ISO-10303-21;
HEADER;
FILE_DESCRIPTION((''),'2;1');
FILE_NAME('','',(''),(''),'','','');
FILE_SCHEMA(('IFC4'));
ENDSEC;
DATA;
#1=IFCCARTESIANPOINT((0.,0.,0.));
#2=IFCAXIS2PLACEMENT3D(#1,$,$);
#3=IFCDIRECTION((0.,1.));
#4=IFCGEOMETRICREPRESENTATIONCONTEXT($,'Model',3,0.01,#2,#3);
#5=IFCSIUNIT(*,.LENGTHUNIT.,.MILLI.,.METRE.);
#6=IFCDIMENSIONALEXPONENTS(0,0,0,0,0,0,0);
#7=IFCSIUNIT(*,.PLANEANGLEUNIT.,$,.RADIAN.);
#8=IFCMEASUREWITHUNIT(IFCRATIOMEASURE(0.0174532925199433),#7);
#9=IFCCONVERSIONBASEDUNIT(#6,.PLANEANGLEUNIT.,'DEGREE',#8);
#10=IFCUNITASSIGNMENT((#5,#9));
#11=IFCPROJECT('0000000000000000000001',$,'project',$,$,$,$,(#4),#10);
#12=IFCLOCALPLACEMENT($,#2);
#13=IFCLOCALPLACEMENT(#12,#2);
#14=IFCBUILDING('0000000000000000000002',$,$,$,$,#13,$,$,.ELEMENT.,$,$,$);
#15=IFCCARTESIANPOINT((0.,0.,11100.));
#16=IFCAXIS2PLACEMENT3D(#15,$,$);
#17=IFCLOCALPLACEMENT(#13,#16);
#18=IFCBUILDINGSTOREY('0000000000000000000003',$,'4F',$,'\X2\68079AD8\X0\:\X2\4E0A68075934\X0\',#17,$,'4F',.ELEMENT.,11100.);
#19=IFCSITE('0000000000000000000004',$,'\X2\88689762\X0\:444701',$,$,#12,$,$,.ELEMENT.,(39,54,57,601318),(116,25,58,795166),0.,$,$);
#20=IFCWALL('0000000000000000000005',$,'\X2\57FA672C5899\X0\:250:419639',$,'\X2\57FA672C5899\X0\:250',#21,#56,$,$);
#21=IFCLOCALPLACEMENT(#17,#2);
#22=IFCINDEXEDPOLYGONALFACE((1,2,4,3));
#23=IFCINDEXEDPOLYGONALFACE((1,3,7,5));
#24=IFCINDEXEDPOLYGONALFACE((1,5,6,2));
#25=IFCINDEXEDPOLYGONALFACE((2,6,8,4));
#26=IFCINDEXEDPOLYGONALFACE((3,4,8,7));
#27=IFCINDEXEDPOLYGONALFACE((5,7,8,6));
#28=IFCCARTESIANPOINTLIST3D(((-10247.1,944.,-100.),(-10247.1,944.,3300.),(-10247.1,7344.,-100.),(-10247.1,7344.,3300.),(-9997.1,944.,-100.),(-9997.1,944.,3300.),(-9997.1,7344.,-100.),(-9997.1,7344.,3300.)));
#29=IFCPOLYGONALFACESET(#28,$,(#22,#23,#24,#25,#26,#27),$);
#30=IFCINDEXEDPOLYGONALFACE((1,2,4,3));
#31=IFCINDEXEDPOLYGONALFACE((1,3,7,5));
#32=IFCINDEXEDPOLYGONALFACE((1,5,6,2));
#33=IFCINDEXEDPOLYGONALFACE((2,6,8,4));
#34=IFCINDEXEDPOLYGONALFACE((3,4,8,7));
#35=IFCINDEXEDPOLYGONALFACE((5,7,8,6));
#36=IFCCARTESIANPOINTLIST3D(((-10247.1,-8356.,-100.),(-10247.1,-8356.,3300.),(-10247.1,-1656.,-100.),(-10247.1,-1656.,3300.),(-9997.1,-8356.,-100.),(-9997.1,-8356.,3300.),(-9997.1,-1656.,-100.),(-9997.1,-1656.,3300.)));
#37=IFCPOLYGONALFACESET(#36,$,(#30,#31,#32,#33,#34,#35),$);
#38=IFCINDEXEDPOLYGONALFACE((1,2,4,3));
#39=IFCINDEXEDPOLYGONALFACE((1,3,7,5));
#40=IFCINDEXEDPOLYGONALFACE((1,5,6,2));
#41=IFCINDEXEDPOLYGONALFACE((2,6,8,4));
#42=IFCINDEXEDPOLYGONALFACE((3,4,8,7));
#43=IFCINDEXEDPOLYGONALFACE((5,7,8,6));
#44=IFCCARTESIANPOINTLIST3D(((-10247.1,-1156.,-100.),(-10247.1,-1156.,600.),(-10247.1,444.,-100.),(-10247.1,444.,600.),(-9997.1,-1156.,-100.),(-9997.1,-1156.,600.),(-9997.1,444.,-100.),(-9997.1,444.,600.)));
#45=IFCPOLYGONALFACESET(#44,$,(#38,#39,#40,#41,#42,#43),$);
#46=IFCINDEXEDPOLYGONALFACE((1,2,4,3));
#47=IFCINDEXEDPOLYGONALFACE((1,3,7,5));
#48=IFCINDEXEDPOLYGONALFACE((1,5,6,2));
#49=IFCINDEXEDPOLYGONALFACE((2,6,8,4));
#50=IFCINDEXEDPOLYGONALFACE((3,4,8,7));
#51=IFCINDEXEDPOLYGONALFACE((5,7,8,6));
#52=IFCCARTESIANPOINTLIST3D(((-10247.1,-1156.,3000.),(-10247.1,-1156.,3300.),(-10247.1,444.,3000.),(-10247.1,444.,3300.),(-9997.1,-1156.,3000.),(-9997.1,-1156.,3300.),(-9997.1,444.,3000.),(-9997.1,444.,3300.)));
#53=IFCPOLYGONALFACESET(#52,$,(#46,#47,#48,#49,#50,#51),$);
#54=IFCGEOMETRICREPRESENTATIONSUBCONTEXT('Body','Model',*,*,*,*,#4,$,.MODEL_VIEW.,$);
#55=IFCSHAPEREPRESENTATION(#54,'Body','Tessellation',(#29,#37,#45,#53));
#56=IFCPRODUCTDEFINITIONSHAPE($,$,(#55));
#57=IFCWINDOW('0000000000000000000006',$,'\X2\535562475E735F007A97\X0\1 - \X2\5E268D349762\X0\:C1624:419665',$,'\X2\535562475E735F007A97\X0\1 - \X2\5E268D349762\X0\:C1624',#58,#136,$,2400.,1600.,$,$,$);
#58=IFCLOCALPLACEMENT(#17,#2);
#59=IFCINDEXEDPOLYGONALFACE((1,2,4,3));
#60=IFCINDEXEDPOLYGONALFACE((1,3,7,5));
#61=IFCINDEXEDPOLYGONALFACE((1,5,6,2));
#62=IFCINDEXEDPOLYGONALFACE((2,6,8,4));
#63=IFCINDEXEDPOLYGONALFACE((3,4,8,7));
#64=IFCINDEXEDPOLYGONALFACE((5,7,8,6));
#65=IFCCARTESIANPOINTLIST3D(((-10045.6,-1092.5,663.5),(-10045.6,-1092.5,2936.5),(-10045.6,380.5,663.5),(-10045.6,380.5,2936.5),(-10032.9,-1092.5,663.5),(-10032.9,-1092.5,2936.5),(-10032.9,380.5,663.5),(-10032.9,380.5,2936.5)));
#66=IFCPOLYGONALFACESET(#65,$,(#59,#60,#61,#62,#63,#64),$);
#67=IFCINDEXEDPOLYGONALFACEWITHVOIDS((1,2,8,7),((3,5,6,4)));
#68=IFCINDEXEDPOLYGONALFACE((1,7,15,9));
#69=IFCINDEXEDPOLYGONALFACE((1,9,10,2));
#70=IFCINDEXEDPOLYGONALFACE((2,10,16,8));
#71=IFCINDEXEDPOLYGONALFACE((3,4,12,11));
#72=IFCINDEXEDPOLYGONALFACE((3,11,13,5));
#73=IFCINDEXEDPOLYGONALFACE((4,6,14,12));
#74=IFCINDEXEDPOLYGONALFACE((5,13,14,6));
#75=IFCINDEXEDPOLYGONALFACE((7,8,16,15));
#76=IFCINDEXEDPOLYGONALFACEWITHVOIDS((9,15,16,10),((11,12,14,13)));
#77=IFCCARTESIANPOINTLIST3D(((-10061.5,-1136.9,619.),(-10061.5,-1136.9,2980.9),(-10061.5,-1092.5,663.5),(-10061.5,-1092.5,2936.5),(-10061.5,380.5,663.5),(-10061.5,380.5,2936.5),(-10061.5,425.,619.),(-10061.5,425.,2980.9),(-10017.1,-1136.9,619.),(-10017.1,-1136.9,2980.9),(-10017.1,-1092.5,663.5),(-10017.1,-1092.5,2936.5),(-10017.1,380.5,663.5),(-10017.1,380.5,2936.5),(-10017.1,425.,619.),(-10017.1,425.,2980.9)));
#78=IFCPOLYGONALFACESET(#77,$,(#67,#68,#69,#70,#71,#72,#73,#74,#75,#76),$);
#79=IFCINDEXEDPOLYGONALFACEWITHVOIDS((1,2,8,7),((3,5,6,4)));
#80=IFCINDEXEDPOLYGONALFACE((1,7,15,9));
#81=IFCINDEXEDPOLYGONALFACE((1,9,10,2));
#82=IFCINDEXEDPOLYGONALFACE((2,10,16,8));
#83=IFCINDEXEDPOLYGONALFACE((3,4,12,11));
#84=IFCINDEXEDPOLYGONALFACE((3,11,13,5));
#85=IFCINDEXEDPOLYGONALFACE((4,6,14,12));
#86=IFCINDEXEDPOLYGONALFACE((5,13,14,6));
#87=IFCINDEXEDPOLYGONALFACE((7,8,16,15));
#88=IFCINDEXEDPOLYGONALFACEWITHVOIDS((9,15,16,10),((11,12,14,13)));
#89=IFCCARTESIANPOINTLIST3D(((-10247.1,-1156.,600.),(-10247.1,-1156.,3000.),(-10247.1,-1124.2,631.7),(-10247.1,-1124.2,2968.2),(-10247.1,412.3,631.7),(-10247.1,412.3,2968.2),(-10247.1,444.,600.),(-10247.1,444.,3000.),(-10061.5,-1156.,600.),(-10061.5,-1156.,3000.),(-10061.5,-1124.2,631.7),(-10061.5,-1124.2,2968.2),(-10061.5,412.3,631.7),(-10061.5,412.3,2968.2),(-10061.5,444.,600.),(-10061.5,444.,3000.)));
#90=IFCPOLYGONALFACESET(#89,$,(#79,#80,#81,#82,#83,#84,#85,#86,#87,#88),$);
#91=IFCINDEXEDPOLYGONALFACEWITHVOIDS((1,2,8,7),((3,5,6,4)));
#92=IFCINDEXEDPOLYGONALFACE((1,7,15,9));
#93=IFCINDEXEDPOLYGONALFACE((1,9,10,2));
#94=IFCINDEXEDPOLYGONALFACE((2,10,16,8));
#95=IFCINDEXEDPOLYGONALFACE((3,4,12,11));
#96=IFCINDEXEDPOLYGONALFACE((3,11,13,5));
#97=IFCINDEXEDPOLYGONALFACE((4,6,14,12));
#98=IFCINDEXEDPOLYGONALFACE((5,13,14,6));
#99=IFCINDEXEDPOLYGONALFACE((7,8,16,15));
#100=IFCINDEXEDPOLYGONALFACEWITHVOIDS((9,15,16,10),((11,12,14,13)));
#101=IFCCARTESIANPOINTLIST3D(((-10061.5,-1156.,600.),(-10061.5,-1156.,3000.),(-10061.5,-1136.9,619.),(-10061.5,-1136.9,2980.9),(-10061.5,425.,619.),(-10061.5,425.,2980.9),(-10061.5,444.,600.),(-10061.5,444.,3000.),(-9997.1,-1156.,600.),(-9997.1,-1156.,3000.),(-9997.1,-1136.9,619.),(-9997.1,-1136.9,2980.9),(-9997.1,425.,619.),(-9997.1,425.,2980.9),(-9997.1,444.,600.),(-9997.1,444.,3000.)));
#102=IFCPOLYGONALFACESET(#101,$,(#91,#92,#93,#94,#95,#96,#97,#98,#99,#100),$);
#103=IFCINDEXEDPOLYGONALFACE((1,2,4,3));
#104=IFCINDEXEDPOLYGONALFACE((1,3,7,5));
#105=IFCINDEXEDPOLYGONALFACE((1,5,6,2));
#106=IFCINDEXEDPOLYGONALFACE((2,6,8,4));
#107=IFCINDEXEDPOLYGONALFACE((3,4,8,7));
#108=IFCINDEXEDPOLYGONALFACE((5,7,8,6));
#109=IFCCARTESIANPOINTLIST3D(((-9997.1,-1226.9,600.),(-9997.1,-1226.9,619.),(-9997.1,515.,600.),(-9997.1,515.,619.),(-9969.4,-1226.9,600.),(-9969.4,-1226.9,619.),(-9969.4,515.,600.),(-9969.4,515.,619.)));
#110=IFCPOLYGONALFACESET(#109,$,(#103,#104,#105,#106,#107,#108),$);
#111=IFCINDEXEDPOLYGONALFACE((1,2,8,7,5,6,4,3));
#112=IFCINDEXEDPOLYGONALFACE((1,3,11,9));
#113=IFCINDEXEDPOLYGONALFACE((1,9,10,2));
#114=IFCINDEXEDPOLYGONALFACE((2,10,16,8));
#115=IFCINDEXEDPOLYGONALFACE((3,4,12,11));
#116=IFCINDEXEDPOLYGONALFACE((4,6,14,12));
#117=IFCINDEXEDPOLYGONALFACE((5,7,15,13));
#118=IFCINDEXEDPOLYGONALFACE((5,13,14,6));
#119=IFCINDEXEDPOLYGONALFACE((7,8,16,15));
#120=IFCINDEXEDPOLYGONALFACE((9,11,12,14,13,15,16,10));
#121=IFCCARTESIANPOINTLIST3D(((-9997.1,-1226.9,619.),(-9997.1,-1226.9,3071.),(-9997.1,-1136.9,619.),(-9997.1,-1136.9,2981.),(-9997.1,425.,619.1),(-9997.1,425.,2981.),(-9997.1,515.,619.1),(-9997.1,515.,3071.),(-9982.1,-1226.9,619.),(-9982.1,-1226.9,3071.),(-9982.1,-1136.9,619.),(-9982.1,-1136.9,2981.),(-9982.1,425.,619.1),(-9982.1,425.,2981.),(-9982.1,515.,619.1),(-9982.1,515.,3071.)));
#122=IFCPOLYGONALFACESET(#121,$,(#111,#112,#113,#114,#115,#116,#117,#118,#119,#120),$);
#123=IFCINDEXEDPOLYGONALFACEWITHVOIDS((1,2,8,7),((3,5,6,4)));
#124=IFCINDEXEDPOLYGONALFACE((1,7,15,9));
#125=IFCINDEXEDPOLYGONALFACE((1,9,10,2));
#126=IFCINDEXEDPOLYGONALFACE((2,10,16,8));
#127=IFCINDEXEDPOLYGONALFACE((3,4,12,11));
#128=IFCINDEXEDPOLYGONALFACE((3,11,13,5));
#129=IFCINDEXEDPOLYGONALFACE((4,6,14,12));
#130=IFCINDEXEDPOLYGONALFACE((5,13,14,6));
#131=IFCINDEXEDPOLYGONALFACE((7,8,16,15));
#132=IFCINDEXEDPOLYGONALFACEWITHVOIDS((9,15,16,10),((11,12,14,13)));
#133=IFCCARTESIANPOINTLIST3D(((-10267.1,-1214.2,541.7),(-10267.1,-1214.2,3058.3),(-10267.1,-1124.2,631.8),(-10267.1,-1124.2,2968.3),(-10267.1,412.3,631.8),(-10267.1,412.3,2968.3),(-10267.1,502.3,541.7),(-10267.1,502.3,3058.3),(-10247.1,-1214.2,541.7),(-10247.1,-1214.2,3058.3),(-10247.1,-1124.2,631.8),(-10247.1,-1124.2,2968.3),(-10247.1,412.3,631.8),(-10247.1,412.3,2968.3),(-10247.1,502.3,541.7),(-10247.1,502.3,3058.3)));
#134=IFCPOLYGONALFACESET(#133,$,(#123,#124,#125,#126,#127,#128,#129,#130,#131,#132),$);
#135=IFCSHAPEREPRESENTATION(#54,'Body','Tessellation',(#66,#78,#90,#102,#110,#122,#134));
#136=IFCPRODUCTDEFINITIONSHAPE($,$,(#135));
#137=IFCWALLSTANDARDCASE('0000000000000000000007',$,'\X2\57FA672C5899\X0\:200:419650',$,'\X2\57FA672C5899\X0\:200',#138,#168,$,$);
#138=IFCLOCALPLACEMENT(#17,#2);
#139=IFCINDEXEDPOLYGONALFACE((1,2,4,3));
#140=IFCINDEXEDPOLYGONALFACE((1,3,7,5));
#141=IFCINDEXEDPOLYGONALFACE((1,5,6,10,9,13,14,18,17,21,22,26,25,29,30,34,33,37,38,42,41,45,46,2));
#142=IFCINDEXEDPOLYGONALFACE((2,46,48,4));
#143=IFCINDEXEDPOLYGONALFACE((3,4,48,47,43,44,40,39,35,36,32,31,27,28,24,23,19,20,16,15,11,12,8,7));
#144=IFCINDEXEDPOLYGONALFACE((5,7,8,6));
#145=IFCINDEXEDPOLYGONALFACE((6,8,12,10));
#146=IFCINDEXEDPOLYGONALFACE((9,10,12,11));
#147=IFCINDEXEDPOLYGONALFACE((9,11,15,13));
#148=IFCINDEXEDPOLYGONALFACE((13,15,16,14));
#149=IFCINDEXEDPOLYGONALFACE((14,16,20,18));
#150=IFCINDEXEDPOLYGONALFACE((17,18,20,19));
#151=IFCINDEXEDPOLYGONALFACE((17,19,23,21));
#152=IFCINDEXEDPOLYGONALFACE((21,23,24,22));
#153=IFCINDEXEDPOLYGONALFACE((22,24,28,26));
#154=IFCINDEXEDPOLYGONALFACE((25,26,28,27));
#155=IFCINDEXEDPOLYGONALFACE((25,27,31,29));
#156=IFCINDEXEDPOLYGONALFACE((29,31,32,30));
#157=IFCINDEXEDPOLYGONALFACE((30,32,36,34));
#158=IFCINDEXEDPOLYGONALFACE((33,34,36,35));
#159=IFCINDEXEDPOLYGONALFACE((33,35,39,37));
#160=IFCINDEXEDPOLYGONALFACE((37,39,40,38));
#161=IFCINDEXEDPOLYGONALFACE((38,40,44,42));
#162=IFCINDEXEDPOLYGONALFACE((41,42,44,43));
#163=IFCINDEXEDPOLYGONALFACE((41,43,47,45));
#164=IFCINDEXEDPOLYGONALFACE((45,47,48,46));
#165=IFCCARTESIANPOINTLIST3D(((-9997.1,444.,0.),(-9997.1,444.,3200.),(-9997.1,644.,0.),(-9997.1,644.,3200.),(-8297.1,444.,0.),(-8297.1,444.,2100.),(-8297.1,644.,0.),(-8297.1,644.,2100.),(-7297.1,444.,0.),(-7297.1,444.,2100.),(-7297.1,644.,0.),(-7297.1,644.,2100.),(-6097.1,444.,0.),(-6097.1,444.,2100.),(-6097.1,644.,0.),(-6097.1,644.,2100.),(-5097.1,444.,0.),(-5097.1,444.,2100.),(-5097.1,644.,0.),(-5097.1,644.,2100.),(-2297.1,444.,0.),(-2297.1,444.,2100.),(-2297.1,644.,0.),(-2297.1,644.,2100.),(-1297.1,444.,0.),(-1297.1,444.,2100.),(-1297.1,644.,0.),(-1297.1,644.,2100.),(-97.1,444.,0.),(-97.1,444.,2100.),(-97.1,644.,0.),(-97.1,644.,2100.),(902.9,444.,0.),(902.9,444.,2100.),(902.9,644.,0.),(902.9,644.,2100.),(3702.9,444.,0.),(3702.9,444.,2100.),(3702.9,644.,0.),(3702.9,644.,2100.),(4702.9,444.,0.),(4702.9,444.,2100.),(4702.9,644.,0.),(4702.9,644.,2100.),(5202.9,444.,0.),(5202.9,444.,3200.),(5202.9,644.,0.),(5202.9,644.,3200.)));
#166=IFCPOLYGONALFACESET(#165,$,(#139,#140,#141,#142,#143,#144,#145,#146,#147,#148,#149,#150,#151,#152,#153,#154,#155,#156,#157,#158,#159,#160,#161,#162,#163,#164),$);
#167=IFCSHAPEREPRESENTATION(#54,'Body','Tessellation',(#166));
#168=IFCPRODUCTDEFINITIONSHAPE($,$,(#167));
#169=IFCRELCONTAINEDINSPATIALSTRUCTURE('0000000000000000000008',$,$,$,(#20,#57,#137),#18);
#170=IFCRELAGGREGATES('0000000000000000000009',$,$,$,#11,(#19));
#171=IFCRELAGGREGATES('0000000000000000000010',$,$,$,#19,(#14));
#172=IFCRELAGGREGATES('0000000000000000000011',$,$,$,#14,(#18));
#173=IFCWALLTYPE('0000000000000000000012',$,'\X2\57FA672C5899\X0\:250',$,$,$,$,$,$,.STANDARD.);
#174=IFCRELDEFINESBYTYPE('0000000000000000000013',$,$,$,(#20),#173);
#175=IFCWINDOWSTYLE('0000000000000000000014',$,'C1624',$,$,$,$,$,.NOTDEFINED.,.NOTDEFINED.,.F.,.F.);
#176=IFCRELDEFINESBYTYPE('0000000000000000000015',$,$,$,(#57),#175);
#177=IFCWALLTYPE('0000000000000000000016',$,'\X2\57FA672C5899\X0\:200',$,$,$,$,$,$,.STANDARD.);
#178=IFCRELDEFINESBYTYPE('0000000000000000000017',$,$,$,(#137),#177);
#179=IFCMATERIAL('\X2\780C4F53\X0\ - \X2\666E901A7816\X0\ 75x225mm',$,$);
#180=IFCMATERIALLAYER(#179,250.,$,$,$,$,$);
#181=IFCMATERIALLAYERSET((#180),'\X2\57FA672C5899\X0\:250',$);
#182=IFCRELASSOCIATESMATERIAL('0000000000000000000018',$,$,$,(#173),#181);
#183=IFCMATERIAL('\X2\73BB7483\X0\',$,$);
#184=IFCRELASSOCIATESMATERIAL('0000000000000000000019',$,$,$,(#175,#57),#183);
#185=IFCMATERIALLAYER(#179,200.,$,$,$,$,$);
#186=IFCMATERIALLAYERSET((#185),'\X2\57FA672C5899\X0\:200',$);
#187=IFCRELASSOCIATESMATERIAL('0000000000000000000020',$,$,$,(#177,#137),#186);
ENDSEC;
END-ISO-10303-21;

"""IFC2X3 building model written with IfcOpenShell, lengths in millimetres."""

from ifc_helpers import new_model, entity, si_unit, converted_unit, direction, frame, frame_2d, origin, origin_2d_with_axis, place, context, subcontext, project, spatial, polyline, rectangle, outline, extrude, source, transform, mapped, material, layer, layer_set, layer_usage, type_object, type_shapes, element, fill, save


model = new_model("IFC2X3")

# Units and contexts
model_context = context("Model", 3, precision=0.01, world=origin(), true_north=direction((0.0, 1.0)))
body_context = subcontext(model_context, "Body", "Model", "MODEL_VIEW")
ifc_project = project(units=[si_unit("LENGTHUNIT", "METRE", prefix="MILLI"), converted_unit("PLANEANGLEUNIT", "DEGREE", entity("IfcRatioMeasure", 0.0174532925199433), si_unit("PLANEANGLEUNIT", "RADIAN"), dimensions=[0, 0, 0, 0, 0, 0, 0])], contexts=[model_context])

# Site, building, storey
site_placement = place(None, origin())
site = spatial("IfcSite", under=ifc_project, at=site_placement, Name="表面:444701", CompositionType="ELEMENT", RefLatitude=(39, 54, 57, 601318), RefLongitude=(116, 25, 58, 795166), RefElevation=0.0)
building_placement = place(site_placement, origin())
building = spatial("IfcBuilding", under=site, at=building_placement, CompositionType="ELEMENT")
storey_placement = place(building_placement, frame((0.0, 0.0, 11100.0)))
storey = spatial("IfcBuildingStorey", under=building, at=storey_placement, Name="4F", ObjectType="标高:上标头", LongName="4F", CompositionType="ELEMENT", Elevation=11100.0)

# Wall, opening, window
ifc_material_1 = material(Name="砌体 - 普通砖 75x225mm")
ifc_layer_1 = layer(ifc_material_1, 250.0)
ifc_layer_set_1 = layer_set([ifc_layer_1], Name="基本墙:250")
wall_type_1 = type_object("IfcWallType", Name="基本墙:250", PredefinedType="STANDARD", material=ifc_layer_set_1)
wall_1_placement = place(storey_placement, frame((-10122.1, 7344.0, -100.0), z_axis=(0.0, 0.0, 1.0), x_axis=(0.0, -1.0, 0.0)))
wall_1 = element("IfcWall", 1, at=wall_1_placement, inside=storey, type_object=wall_type_1, Name="基本墙:250:419639", ObjectType="基本墙:250", context=body_context, shape_type="SweptSolid", body=[
    extrude(rectangle(XDim=6400.0, YDim=250.0, at=frame_2d((0.0, 0.0), x_axis=(1.0, 0.0))), frame((3200.0, 0.0, 0.0)), (0.0, 0.0, 1.0), 3400.0),
    extrude(rectangle(XDim=6700.0, YDim=250.0, at=frame_2d((0.0, 0.0), x_axis=(1.0, 0.0))), frame((12350.0, 0.0, 0.0)), (0.0, 0.0, 1.0), 3400.0),
    extrude(rectangle(XDim=1600.0, YDim=250.0, at=frame_2d((0.0, 0.0), x_axis=(1.0, 0.0))), frame((7700.0, 0.0, 0.0)), (0.0, 0.0, 1.0), 700.0),
    extrude(rectangle(XDim=250.0, YDim=1600.0, at=frame_2d((0.0, 0.0), x_axis=(1.0, 0.0))), frame((7700.0, 0.0, 3100.0), z_axis=(0.0, 0.0, 1.0), x_axis=(0.0, 1.0, 0.0)), (0.0, 0.0, 1.0), 300.0),
])
opening_1_placement = place(wall_1_placement, frame((6900.0, -125.0, 700.0)))
opening_1 = element("IfcOpeningElement", 2, at=opening_1_placement, cuts=wall_1, ObjectType="Opening", context=body_context, shape_type="SweptSolid", body=[
    extrude(rectangle(XDim=2400.0, YDim=1600.0, at=frame_2d((1200.0, 800.0), x_axis=(-1.0, 0.0))), frame((0.0, 0.0, 0.0), z_axis=(0.0, 1.0, 0.0), x_axis=(0.0, 0.0, 1.0)), (0.0, 0.0, 1.0), 250.0),
])
ifc_material_2 = material(Name="玻璃")
window_style_1 = type_object("IfcWindowStyle", Name="C1624", ConstructionType="NOTDEFINED", OperationType="NOTDEFINED", ParameterTakesPrecedence=False, Sizeable=False, material=ifc_material_2)
shared_shape_1 = source(origin(), body_context, "Body", "SweptSolid", [
    extrude(rectangle(XDim=12.7, YDim=1473.0, at=origin_2d_with_axis()), frame((800.0, 207.8, 63.5), z_axis=(0.0, 0.0, 1.0), x_axis=(0.0, 1.0, 0.0)), (0.0, 0.0, 1.0), 2273.0),
    extrude(outline(polyline([(-780.9, -1181.0), (780.9, -1181.0), (780.9, 1181.0), (-780.9, 1181.0), (-780.9, -1181.0)]), holes=[polyline([(-736.5, -1136.5), (-736.5, 1136.5), (736.5, 1136.5), (736.5, -1136.5), (-736.5, -1136.5)])]), frame((800.0, 185.6, 1200.0), z_axis=(0.0, 1.0, 0.0), x_axis=(1.0, 0.0, 0.0)), (0.0, 0.0, 1.0), 44.5),
    extrude(outline(polyline([(-800.0, -1200.0), (800.0, -1200.0), (800.0, 1200.0), (-800.0, 1200.0), (-800.0, -1200.0)]), holes=[polyline([(-768.2, -1168.2), (-768.2, 1168.2), (768.2, 1168.2), (768.2, -1168.2), (-768.2, -1168.2)])]), frame((800.0, 0.0, 1200.0), z_axis=(0.0, 1.0, 0.0), x_axis=(1.0, 0.0, 0.0)), (0.0, 0.0, 1.0), 185.6),
    extrude(outline(polyline([(-1200.0, -800.0), (1200.0, -800.0), (1200.0, 800.0), (-1200.0, 800.0), (-1200.0, -800.0)]), holes=[polyline([(-1181.0, -780.9), (-1181.0, 781.0), (1181.0, 781.0), (1181.0, -780.9), (-1181.0, -780.9)])]), frame((800.0, 185.6, 1200.0), z_axis=(0.0, 1.0, 0.0), x_axis=(0.0, 0.0, -1.0)), (0.0, 0.0, 1.0), 64.5),
    extrude(rectangle(XDim=27.7, YDim=1741.9, at=frame_2d((0.0, 0.0), x_axis=(1.0, 0.0))), frame((800.0, 263.9, 0.0), z_axis=(0.0, 0.0, 1.0), x_axis=(0.0, -1.0, 0.0)), (0.0, 0.0, 1.0), 19.0),
    extrude(outline(polyline([(-1158.5, 780.9), (1203.5, 780.9), (1203.5, 870.9), (-1248.5, 870.9), (-1248.5, -870.9), (1203.5, -870.9), (1203.5, -780.9), (-1158.5, -780.9), (-1158.5, 780.9)])), frame((800.0, 250.0, 1222.5), z_axis=(0.0, 1.0, 0.0), x_axis=(0.0, 0.0, -1.0)), (0.0, 0.0, 1.0), 15.0),
    extrude(outline(polyline([(-1258.3, -858.2), (1258.3, -858.2), (1258.3, 858.2), (-1258.3, 858.2), (-1258.3, -858.2)]), holes=[polyline([(-1168.3, -768.2), (-1168.3, 768.3), (1168.2, 768.3), (1168.2, -768.2), (-1168.3, -768.2)])]), frame((800.0, -20.0, 1200.0), z_axis=(0.0, 1.0, 0.0), x_axis=(0.0, 0.0, -1.0)), (0.0, 0.0, 1.0), 20.0),
])
type_shapes(window_style_1, [shared_shape_1])
window_1_placement = place(opening_1_placement, origin())
window_1 = element("IfcWindow", 3, at=window_1_placement, inside=storey, type_object=window_style_1, material=ifc_material_2, Name="单扇平开窗1 - 带贴面:C1624:419665", ObjectType="单扇平开窗1 - 带贴面:C1624", OverallHeight=2400.0, OverallWidth=1600.0, context=body_context, shape_type="MappedRepresentation", body=[
    mapped(shared_shape_1, transform((0.0, 0.0, 0.0), scale=1.0)),
])
fill(opening_1, window_1)

# Wall, openings
ifc_layer_2 = layer(ifc_material_1, 200.0)
ifc_layer_set_2 = layer_set([ifc_layer_2], Name="基本墙:200")
ifc_layer_usage_1 = layer_usage(ifc_layer_set_2, "AXIS2", "NEGATIVE", 100.0)
wall_type_2 = type_object("IfcWallType", Name="基本墙:200", PredefinedType="STANDARD", material=ifc_layer_set_2)
wall_2_placement = place(storey_placement, frame((-9997.1, 544.0, 0.0)))
wall_2 = element("IfcWallStandardCase", 4, at=wall_2_placement, inside=storey, type_object=wall_type_2, material=ifc_layer_usage_1, Name="基本墙:200:419650", ObjectType="基本墙:200", context=body_context, shape_type="SweptSolid", body=[
    extrude(rectangle(XDim=15200.0, YDim=200.0, at=frame_2d((7600.0, 0.0), x_axis=(-1.0, 0.0))), origin(), (0.0, 0.0, 1.0), 3200.0),
])
opening_2_placement = place(wall_2_placement, frame((1700.0, -100.0, 0.0)))
element("IfcOpeningElement", 5, at=opening_2_placement, cuts=wall_2, ObjectType="Opening", context=body_context, shape_type="SweptSolid", body=[
    extrude(rectangle(XDim=2100.0, YDim=1000.0, at=frame_2d((1050.0, 500.0), x_axis=(1.0, 0.0))), frame((0.0, 0.0, 0.0), z_axis=(0.0, 1.0, 0.0), x_axis=(0.0, 0.0, 1.0)), (0.0, 0.0, 1.0), 200.0),
])
opening_3_placement = place(wall_2_placement, frame((3900.0, -100.0, 0.0)))
element("IfcOpeningElement", 6, at=opening_3_placement, cuts=wall_2, ObjectType="Opening", context=body_context, shape_type="SweptSolid", body=[
    extrude(rectangle(XDim=2100.0, YDim=1000.0, at=frame_2d((1050.0, 500.0), x_axis=(1.0, 0.0))), frame((0.0, 0.0, 0.0), z_axis=(0.0, 1.0, 0.0), x_axis=(0.0, 0.0, 1.0)), (0.0, 0.0, 1.0), 200.0),
])
opening_4_placement = place(wall_2_placement, frame((7700.0, -100.0, 0.0)))
element("IfcOpeningElement", 7, at=opening_4_placement, cuts=wall_2, ObjectType="Opening", context=body_context, shape_type="SweptSolid", body=[
    extrude(rectangle(XDim=2100.0, YDim=1000.0, at=frame_2d((1050.0, 500.0), x_axis=(1.0, 0.0))), frame((0.0, 0.0, 0.0), z_axis=(0.0, 1.0, 0.0), x_axis=(0.0, 0.0, 1.0)), (0.0, 0.0, 1.0), 200.0),
])
opening_5_placement = place(wall_2_placement, frame((9900.0, -100.0, 0.0)))
element("IfcOpeningElement", 8, at=opening_5_placement, cuts=wall_2, ObjectType="Opening", context=body_context, shape_type="SweptSolid", body=[
    extrude(rectangle(XDim=2100.0, YDim=1000.0, at=frame_2d((1050.0, 500.0), x_axis=(1.0, 0.0))), frame((0.0, 0.0, 0.0), z_axis=(0.0, 1.0, 0.0), x_axis=(0.0, 0.0, 1.0)), (0.0, 0.0, 1.0), 200.0),
])
opening_6_placement = place(wall_2_placement, frame((13700.0, -100.0, 0.0)))
element("IfcOpeningElement", 9, at=opening_6_placement, cuts=wall_2, ObjectType="Opening", context=body_context, shape_type="SweptSolid", body=[
    extrude(rectangle(XDim=2100.0, YDim=1000.0, at=frame_2d((1050.0, 500.0), x_axis=(1.0, 0.0))), frame((0.0, 0.0, 0.0), z_axis=(0.0, 1.0, 0.0), x_axis=(0.0, 0.0, 1.0)), (0.0, 0.0, 1.0), 200.0),
])

save(model, "model.ifc")
